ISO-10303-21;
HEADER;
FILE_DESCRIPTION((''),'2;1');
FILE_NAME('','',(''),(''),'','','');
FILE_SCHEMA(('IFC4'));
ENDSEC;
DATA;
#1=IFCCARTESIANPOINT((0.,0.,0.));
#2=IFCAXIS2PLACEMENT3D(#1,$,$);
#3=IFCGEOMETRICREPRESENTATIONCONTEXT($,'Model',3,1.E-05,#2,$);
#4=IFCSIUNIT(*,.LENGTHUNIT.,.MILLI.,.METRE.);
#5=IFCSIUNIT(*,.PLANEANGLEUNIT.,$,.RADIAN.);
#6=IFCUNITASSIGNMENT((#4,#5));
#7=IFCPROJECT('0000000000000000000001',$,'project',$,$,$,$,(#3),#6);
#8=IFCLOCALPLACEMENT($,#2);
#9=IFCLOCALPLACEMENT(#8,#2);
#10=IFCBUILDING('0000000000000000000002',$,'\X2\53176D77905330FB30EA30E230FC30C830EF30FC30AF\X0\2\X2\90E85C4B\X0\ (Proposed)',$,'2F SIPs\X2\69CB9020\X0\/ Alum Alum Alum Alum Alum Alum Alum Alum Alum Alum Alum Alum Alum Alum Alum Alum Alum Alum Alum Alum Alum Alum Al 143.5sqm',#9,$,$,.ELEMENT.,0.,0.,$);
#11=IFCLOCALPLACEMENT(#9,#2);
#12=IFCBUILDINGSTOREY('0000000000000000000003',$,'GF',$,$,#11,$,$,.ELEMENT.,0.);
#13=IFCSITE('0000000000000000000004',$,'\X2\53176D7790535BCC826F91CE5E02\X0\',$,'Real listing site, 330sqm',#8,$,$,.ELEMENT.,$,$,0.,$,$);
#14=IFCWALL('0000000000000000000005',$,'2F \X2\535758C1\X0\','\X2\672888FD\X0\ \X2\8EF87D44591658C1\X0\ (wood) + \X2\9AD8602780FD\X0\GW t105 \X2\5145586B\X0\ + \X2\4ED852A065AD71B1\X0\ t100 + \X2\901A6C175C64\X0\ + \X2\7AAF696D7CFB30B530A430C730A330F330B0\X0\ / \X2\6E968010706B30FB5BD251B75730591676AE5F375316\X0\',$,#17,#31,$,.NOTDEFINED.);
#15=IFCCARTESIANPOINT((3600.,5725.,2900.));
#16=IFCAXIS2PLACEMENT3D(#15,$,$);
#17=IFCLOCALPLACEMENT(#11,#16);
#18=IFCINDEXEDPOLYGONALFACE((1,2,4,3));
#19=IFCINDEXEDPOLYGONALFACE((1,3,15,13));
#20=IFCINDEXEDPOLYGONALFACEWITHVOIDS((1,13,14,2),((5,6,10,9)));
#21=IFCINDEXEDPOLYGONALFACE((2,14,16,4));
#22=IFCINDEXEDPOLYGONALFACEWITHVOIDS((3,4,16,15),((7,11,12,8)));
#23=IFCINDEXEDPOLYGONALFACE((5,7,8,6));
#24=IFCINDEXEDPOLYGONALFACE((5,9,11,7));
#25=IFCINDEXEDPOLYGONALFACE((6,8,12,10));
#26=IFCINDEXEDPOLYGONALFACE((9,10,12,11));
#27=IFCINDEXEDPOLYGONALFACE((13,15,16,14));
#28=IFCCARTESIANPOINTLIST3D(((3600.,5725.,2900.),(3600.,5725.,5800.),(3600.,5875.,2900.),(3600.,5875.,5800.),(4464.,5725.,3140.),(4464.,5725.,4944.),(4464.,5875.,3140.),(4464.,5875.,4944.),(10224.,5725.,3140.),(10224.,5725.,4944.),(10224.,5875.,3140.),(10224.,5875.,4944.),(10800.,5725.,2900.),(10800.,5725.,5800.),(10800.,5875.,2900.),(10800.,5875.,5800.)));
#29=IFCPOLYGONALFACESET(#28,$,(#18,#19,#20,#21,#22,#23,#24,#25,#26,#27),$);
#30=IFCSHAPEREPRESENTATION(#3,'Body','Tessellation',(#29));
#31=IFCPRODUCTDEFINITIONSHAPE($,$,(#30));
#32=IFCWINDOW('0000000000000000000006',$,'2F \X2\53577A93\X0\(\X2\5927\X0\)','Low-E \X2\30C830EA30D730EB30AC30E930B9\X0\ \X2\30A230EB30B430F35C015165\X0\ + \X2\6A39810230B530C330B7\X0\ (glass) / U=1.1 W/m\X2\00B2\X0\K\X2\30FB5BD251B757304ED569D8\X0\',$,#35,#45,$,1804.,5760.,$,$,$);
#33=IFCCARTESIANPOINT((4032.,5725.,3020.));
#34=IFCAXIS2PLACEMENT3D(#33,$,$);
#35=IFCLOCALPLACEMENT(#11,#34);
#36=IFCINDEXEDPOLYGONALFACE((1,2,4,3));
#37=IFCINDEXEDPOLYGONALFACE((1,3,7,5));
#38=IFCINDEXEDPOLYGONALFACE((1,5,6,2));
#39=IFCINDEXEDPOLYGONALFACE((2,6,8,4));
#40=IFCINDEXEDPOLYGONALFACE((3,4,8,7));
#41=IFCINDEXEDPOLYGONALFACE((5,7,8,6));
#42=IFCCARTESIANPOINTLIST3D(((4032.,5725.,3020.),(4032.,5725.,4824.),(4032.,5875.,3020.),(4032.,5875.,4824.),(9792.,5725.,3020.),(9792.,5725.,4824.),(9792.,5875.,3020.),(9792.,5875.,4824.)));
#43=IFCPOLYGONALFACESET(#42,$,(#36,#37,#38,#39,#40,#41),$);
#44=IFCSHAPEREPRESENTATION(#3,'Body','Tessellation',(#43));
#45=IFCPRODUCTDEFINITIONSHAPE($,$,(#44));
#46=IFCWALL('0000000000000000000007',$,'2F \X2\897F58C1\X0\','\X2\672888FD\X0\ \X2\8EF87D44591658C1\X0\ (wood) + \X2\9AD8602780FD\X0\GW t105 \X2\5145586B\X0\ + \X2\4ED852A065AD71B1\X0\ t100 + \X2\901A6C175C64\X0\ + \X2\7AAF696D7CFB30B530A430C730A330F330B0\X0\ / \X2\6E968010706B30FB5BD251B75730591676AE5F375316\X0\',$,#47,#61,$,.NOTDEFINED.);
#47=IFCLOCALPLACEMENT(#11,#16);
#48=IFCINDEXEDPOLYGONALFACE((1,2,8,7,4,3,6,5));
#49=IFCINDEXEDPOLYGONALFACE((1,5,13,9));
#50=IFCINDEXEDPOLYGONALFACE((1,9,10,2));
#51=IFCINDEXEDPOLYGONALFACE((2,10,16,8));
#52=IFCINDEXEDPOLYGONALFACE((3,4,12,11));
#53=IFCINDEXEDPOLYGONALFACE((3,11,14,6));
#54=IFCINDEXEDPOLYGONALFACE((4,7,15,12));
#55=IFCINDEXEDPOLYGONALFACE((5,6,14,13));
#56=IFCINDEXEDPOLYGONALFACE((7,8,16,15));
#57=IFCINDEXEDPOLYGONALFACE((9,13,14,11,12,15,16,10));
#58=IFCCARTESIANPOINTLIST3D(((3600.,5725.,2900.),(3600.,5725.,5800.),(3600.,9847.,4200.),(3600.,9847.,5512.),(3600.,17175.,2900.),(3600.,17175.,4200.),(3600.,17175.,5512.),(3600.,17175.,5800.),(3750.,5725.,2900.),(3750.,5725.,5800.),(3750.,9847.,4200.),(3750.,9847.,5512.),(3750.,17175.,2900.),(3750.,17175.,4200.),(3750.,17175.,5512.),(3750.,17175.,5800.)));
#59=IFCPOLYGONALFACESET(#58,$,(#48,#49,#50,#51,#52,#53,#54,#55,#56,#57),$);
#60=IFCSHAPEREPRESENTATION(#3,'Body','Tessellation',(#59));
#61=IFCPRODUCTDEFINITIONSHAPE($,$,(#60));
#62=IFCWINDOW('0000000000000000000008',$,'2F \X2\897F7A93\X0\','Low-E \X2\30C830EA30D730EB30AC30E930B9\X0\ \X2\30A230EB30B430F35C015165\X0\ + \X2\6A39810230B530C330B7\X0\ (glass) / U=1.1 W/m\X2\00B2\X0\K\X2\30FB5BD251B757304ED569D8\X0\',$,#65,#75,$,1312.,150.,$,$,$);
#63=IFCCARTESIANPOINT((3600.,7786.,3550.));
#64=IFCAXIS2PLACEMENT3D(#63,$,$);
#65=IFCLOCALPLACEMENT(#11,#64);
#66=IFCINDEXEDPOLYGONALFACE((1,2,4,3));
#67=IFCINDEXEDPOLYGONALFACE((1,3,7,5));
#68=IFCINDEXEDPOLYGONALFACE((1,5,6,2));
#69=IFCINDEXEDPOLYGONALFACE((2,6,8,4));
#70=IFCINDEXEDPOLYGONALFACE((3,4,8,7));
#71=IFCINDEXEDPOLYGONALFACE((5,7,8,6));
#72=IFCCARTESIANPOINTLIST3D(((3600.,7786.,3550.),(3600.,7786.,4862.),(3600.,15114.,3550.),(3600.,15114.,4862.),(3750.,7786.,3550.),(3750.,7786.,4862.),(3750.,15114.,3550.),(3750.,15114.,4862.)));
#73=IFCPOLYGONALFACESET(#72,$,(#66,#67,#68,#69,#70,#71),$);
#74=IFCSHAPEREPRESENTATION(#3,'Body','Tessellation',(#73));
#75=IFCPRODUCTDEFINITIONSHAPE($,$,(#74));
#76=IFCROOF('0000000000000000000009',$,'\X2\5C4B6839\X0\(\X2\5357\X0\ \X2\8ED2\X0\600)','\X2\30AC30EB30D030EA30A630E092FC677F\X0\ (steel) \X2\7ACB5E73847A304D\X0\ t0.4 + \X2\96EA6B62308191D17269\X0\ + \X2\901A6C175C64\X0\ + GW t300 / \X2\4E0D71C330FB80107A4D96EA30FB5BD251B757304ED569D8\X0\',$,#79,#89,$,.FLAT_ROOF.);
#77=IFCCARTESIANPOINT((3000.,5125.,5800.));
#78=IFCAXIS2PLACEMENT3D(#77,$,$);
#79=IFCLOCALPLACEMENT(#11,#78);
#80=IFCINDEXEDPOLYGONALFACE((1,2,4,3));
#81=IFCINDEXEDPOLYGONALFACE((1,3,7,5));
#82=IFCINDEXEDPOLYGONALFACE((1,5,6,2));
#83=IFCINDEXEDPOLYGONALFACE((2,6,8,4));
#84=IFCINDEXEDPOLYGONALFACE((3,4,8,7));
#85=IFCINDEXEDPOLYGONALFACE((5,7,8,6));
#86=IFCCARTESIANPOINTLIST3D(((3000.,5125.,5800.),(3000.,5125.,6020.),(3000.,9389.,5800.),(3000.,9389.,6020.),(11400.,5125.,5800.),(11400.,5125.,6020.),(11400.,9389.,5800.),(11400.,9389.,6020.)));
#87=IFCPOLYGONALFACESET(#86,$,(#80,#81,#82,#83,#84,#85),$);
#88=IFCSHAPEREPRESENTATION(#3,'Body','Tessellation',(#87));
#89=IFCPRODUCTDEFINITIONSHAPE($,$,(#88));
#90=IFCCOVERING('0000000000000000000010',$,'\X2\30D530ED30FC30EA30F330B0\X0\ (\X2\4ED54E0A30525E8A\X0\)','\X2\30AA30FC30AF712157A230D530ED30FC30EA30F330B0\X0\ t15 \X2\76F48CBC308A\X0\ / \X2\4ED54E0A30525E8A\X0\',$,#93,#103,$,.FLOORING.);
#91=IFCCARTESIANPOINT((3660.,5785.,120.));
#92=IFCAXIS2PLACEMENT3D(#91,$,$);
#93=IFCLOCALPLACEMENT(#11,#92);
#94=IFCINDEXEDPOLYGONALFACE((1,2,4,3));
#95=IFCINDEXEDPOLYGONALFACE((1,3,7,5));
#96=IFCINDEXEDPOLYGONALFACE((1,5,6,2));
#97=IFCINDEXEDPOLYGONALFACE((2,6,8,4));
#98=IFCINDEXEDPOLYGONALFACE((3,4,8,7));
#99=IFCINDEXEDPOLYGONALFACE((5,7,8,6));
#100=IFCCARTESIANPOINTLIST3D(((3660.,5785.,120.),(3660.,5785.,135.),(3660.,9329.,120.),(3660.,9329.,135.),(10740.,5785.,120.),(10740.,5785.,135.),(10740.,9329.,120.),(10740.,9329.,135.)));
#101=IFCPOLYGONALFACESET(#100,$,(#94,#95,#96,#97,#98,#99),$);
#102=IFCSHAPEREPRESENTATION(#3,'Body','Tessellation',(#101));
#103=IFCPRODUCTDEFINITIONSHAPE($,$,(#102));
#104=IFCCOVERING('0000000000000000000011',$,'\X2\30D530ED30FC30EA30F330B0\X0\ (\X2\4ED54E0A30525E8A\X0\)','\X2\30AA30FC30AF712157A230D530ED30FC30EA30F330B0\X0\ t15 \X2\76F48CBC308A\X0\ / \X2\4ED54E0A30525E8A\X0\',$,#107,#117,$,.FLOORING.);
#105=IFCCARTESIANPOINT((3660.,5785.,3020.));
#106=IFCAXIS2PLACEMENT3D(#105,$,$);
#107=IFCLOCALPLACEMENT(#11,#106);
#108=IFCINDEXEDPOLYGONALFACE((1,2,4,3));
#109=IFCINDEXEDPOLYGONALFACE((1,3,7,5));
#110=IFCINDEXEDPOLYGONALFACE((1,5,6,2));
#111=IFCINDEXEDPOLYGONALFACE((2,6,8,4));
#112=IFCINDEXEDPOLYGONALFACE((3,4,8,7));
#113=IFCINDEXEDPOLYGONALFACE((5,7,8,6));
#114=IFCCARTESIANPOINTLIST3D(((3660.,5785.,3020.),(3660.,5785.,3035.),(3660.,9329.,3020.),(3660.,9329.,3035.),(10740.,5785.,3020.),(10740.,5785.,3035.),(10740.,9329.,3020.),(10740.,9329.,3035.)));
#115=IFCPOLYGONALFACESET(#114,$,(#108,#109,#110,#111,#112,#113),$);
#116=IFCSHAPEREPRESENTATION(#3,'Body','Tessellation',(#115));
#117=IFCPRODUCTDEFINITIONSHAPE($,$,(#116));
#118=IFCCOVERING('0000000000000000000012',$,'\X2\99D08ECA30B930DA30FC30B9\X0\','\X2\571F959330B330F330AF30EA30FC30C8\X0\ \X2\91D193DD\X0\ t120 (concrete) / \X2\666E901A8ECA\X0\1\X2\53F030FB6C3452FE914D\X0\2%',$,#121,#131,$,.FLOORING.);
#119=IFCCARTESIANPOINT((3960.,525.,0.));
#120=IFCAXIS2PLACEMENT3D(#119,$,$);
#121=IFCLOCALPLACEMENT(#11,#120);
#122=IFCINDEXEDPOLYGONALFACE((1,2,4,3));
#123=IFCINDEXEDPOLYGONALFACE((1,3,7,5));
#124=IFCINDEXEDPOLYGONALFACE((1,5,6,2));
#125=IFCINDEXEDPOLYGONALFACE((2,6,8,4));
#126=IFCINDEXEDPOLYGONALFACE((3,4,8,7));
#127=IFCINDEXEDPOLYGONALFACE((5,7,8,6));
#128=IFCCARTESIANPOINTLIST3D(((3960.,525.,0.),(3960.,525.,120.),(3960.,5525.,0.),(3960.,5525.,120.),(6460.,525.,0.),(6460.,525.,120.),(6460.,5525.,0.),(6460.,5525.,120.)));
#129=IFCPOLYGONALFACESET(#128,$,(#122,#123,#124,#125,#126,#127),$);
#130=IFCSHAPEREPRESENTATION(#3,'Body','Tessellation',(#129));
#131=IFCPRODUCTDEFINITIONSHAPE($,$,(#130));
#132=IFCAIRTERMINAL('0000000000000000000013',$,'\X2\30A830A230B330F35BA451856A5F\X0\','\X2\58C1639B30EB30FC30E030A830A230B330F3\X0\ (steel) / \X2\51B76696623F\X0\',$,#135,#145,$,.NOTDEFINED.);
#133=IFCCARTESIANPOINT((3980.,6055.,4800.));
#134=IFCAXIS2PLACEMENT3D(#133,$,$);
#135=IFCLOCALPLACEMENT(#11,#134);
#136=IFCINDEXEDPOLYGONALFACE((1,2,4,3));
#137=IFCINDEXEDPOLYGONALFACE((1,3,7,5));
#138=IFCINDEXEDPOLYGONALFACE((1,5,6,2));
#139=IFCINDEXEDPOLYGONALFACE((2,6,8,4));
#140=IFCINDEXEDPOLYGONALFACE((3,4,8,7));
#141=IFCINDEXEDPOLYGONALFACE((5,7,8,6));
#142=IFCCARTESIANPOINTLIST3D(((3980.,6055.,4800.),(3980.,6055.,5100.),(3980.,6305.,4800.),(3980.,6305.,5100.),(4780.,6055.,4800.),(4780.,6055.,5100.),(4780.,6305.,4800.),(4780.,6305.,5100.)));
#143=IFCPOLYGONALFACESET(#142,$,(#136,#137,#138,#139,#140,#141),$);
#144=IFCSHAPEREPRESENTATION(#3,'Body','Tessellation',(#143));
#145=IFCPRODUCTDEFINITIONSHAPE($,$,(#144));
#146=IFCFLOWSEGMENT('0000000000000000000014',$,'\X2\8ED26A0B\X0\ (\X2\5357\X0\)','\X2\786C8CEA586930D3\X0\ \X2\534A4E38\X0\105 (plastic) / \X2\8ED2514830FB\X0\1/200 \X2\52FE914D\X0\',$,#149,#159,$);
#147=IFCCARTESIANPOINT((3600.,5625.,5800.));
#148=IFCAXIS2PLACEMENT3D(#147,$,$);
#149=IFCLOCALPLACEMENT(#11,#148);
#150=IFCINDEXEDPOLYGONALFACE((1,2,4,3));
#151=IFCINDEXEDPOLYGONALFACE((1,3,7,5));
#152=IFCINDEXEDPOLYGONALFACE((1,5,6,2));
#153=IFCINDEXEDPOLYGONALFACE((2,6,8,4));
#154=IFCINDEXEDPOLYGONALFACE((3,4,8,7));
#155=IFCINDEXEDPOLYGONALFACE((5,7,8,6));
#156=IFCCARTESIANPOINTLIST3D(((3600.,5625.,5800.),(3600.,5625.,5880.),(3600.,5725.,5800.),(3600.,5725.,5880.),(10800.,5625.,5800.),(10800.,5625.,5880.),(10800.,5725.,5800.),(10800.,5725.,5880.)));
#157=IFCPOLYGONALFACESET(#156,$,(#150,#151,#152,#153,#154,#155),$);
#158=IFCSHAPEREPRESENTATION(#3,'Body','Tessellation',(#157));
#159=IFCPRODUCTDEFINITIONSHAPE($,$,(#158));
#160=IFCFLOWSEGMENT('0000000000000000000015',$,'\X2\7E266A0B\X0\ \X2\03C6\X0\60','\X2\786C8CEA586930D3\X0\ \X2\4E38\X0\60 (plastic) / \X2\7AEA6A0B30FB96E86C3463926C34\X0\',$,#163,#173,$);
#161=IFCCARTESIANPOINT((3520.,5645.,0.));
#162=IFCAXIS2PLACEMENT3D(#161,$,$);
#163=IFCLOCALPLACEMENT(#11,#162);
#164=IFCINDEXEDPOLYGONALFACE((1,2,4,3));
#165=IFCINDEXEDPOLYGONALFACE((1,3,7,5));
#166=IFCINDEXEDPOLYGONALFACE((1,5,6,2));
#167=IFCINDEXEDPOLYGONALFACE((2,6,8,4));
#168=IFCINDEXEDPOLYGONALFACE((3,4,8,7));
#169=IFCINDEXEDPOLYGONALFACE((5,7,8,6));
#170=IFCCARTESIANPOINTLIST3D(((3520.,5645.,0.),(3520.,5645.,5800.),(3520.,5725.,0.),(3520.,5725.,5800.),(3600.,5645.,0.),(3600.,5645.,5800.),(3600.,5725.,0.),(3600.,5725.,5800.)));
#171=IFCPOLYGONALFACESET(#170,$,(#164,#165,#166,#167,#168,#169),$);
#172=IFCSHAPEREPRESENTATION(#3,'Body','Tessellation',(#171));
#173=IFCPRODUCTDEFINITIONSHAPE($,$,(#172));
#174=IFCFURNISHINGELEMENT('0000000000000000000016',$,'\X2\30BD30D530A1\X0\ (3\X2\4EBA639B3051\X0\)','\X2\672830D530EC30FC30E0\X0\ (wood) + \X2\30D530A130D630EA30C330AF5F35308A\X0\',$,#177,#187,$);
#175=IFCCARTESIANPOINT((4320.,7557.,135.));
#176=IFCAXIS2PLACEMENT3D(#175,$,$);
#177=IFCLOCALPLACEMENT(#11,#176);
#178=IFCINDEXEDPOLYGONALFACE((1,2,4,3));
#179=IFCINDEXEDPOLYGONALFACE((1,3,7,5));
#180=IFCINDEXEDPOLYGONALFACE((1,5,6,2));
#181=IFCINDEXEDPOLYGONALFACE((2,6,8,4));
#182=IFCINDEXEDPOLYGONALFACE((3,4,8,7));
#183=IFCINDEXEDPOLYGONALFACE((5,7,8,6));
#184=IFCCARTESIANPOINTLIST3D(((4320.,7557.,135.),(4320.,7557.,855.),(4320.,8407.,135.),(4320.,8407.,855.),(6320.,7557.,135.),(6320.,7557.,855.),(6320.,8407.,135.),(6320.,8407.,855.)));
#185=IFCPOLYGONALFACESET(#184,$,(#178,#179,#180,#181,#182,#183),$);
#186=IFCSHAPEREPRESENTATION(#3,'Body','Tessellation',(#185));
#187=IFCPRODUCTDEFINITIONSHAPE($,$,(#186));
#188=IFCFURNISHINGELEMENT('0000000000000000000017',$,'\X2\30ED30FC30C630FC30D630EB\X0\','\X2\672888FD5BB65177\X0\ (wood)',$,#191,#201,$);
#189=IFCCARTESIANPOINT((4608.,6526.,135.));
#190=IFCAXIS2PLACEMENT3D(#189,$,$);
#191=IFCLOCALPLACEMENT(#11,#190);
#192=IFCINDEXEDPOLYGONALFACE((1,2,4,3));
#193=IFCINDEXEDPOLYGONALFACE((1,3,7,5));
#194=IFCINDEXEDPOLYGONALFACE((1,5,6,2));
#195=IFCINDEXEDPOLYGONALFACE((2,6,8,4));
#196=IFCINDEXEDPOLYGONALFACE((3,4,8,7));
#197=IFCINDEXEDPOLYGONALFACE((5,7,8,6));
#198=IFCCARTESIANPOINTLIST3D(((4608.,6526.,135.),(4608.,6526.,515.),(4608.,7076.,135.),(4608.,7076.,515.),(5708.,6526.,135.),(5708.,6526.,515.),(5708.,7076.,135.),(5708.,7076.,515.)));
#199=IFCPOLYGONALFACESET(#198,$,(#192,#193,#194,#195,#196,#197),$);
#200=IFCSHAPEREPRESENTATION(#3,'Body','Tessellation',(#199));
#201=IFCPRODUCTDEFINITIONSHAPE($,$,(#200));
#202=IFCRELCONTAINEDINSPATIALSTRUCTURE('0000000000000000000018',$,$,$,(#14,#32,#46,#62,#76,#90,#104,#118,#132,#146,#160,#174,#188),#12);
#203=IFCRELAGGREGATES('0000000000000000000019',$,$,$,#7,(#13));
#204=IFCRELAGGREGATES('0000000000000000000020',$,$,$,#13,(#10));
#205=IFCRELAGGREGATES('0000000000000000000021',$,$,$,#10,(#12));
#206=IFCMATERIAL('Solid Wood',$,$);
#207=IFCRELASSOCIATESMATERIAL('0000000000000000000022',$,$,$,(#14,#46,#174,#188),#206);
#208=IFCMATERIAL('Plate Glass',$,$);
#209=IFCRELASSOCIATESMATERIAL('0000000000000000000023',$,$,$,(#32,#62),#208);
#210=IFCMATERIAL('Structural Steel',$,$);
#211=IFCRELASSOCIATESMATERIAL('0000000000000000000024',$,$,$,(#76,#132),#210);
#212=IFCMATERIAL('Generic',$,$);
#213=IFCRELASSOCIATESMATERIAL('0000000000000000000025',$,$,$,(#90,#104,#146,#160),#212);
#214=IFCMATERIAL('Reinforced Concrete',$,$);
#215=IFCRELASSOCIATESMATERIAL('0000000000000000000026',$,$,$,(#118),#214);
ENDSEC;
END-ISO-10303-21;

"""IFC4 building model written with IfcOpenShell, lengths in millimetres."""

from ifc_helpers import new_model, si_unit, frame, frame_2d, origin, place, context, project, spatial, rectangle, extrude, material, element, fill, save


model = new_model("IFC4")

# Units and contexts
model_context = context("Model", 3, precision=1e-05, world=origin())
ifc_project = project(units=[si_unit("LENGTHUNIT", "METRE", prefix="MILLI"), si_unit("PLANEANGLEUNIT", "RADIAN")], contexts=[model_context])

# Site, building, storey
site_placement = place(None, origin())
site = spatial("IfcSite", under=ifc_project, at=site_placement, Name="北海道富良野市", ObjectType="Real listing site, 330sqm", CompositionType="ELEMENT", RefElevation=0.0)
building_placement = place(site_placement, origin())
building = spatial("IfcBuilding", under=site, at=building_placement, Name="北海道・リモートワーク2部屋 (Proposed)", ObjectType="2F SIPs構造/ Alum Alum Alum Alum Alum Alum Alum Alum Alum Alum Alum Alum Alum Alum Alum Alum Alum Alum Alum Alum Alum Alum Al 143.5sqm", CompositionType="ELEMENT", ElevationOfRefHeight=0.0, ElevationOfTerrain=0.0)
storey_placement = place(building_placement, origin())
storey = spatial("IfcBuildingStorey", under=building, at=storey_placement, Name="GF", CompositionType="ELEMENT", Elevation=0.0)

# Shared definitions
ifc_material_1 = material(Name="Solid Wood")

# Shared definitions
ifc_material_2 = material(Name="Reinforced Concrete")

# Shared definitions
ifc_material_3 = material(Name="Plate Glass")

# Walls, openings, windows
wall_1_placement = place(storey_placement, frame((3600.0, 5725.0, 2900.0)))
wall_1 = element("IfcWall", 1, at=wall_1_placement, inside=storey, material=ifc_material_1, Name="2F 南壁", Description="木製 軸組外壁 (wood) + 高性能GW t105 充填 + 付加断熱 t100 + 通気層 + 窯業系サイディング / 準耐火・寒冷地外皮強化", PredefinedType="NOTDEFINED", context=model_context, shape_type="SweptSolid", body=[
    extrude(rectangle(XDim=7200.0, YDim=150.0, at=frame_2d((3600.0, 75.0))), frame((3600.0, 5725.0, 2900.0)), (0.0, 0.0, 1.0), 2900.0),
])
opening_1_placement = place(storey_placement, frame((4032.0, 5725.0, 3020.0)))
opening_1 = element("IfcOpeningElement", 2, at=opening_1_placement, cuts=wall_1, PredefinedType="NOTDEFINED", context=model_context, shape_type="SweptSolid", body=[
    extrude(rectangle(XDim=5760.0, YDim=150.0, at=frame_2d((2880.0, 75.0))), frame((4032.0, 5725.0, 3020.0)), (0.0, 0.0, 1.0), 1804.0),
])
window_1_placement = place(storey_placement, frame((4032.0, 5725.0, 3020.0)))
window_1 = element("IfcWindow", 3, at=window_1_placement, inside=storey, material=ifc_material_3, Name="2F 南窓(大)", Description="Low-E トリプルガラス アルゴン封入 + 樹脂サッシ (glass) / U=1.1 W/m²K・寒冷地仕様", OverallHeight=1804.0, OverallWidth=5760.0, context=model_context, shape_type="SweptSolid", body=[
    extrude(rectangle(XDim=5760.0, YDim=150.0, at=frame_2d((2880.0, 75.0))), frame((4032.0, 5725.0, 3020.0)), (0.0, 0.0, 1.0), 1804.0),
])
fill(opening_1, window_1)
wall_2_placement = place(storey_placement, frame((3600.0, 5725.0, 2900.0)))
wall_2 = element("IfcWall", 4, at=wall_2_placement, inside=storey, material=ifc_material_1, Name="2F 西壁", Description="木製 軸組外壁 (wood) + 高性能GW t105 充填 + 付加断熱 t100 + 通気層 + 窯業系サイディング / 準耐火・寒冷地外皮強化", PredefinedType="NOTDEFINED", context=model_context, shape_type="SweptSolid", body=[
    extrude(rectangle(XDim=150.0, YDim=11450.0, at=frame_2d((75.0, 5725.0))), frame((3600.0, 5725.0, 2900.0)), (0.0, 0.0, 1.0), 2900.0),
])
opening_2_placement = place(storey_placement, frame((3600.0, 7786.0, 3550.0)))
opening_2 = element("IfcOpeningElement", 5, at=opening_2_placement, cuts=wall_2, PredefinedType="NOTDEFINED", context=model_context, shape_type="SweptSolid", body=[
    extrude(rectangle(XDim=150.0, YDim=7328.0, at=frame_2d((75.0, 3664.0))), frame((3600.0, 7786.0, 3550.0)), (0.0, 0.0, 1.0), 1312.0),
])
window_2_placement = place(storey_placement, frame((3600.0, 7786.0, 3550.0)))
window_2 = element("IfcWindow", 6, at=window_2_placement, inside=storey, material=ifc_material_3, Name="2F 西窓", Description="Low-E トリプルガラス アルゴン封入 + 樹脂サッシ (glass) / U=1.1 W/m²K・寒冷地仕様", OverallHeight=1312.0, OverallWidth=150.0, context=model_context, shape_type="SweptSolid", body=[
    extrude(rectangle(XDim=150.0, YDim=7328.0, at=frame_2d((75.0, 3664.0))), frame((3600.0, 7786.0, 3550.0)), (0.0, 0.0, 1.0), 1312.0),
])
fill(opening_2, window_2)

# Roof
ifc_material_4 = material(Name="Structural Steel")
for number, where, name in (
    (7, (3000.0, 5125.0, 5800.0), "屋根(南 軒600)"),
):
    element("IfcRoof", number, at=place(storey_placement, frame(where)), inside=storey, material=ifc_material_4, Name=name, Description="ガルバリウム鋼板 (steel) 立平葺き t0.4 + 雪止め金物 + 通気層 + GW t300 / 不燃・耐積雪・寒冷地仕様", PredefinedType="FLAT_ROOF", context=model_context, shape_type="SweptSolid", body=[
        extrude(rectangle(XDim=8400.0, YDim=4264.0, at=frame_2d((4200.0, 2132.0))), frame((3000.0, 5125.0, 5800.0)), (0.0, 0.0, 1.0), 220.0),
    ])

# Coverings
ifc_material_5 = material(Name="Generic")
covering_1_placement = place(storey_placement, frame((3660.0, 5785.0, 120.0)))
element("IfcCovering", 8, at=covering_1_placement, inside=storey, material=ifc_material_5, Name="フローリング (仕上げ床)", Description="オーク無垢フローリング t15 直貼り / 仕上げ床", PredefinedType="FLOORING", context=model_context, shape_type="SweptSolid", body=[
    extrude(rectangle(XDim=7080.0, YDim=3544.0, at=frame_2d((3540.0, 1772.0))), frame((3660.0, 5785.0, 120.0)), (0.0, 0.0, 1.0), 15.0),
])
covering_2_placement = place(storey_placement, frame((3660.0, 5785.0, 3020.0)))
element("IfcCovering", 9, at=covering_2_placement, inside=storey, material=ifc_material_5, Name="フローリング (仕上げ床)", Description="オーク無垢フローリング t15 直貼り / 仕上げ床", PredefinedType="FLOORING", context=model_context, shape_type="SweptSolid", body=[
    extrude(rectangle(XDim=7080.0, YDim=3544.0, at=frame_2d((3540.0, 1772.0))), frame((3660.0, 5785.0, 3020.0)), (0.0, 0.0, 1.0), 15.0),
])
covering_3_placement = place(storey_placement, frame((3960.0, 525.0, 0.0)))
element("IfcCovering", 10, at=covering_3_placement, inside=storey, material=ifc_material_2, Name="駐車スペース", Description="土間コンクリート 金鏝 t120 (concrete) / 普通車1台・水勾配2%", PredefinedType="FLOORING", context=model_context, shape_type="SweptSolid", body=[
    extrude(rectangle(XDim=2500.0, YDim=5000.0, at=frame_2d((1250.0, 2500.0))), frame((3960.0, 525.0, 0.0)), (0.0, 0.0, 1.0), 120.0),
])

# Air terminal
air_terminal_placement = place(storey_placement, frame((3980.0, 6055.0, 4800.0)))
element("IfcAirTerminal", 11, at=air_terminal_placement, inside=storey, material=ifc_material_4, Name="エアコン室内機", Description="壁掛ルームエアコン (steel) / 冷暖房", PredefinedType="NOTDEFINED", context=model_context, shape_type="SweptSolid", body=[
    extrude(rectangle(XDim=800.0, YDim=250.0, at=frame_2d((400.0, 125.0))), frame((3980.0, 6055.0, 4800.0)), (0.0, 0.0, 1.0), 300.0),
])

# Flow segments
flow_segment_1_placement = place(storey_placement, frame((3600.0, 5625.0, 5800.0)))
element("IfcFlowSegment", 12, at=flow_segment_1_placement, inside=storey, material=ifc_material_5, Name="軒樋 (南)", Description="硬質塩ビ 半丸105 (plastic) / 軒先・1/200 勾配", context=model_context, shape_type="SweptSolid", body=[
    extrude(rectangle(XDim=7200.0, YDim=100.0, at=frame_2d((3600.0, 50.0))), frame((3600.0, 5625.0, 5800.0)), (0.0, 0.0, 1.0), 80.0),
])
flow_segment_2_placement = place(storey_placement, frame((3520.0, 5645.0, 0.0)))
element("IfcFlowSegment", 13, at=flow_segment_2_placement, inside=storey, material=ifc_material_5, Name="縦樋 φ60", Description="硬質塩ビ 丸60 (plastic) / 竪樋・雨水排水", context=model_context, shape_type="SweptSolid", body=[
    extrude(rectangle(XDim=80.0, YDim=80.0, at=frame_2d((40.0, 40.0))), frame((3520.0, 5645.0, 0.0)), (0.0, 0.0, 1.0), 5800.0),
])

# Furnishing elements
furnishing_1_placement = place(storey_placement, frame((4320.0, 7557.0, 135.0)))
element("IfcFurnishingElement", 14, at=furnishing_1_placement, inside=storey, material=ifc_material_1, Name="ソファ (3人掛け)", Description="木フレーム (wood) + ファブリック張り", context=model_context, shape_type="SweptSolid", body=[
    extrude(rectangle(XDim=2000.0, YDim=850.0, at=frame_2d((1000.0, 425.0))), frame((4320.0, 7557.0, 135.0)), (0.0, 0.0, 1.0), 720.0),
])
furnishing_2_placement = place(storey_placement, frame((4608.0, 6526.0, 135.0)))
element("IfcFurnishingElement", 15, at=furnishing_2_placement, inside=storey, material=ifc_material_1, Name="ローテーブル", Description="木製家具 (wood)", context=model_context, shape_type="SweptSolid", body=[
    extrude(rectangle(XDim=1100.0, YDim=550.0, at=frame_2d((550.0, 275.0))), frame((4608.0, 6526.0, 135.0)), (0.0, 0.0, 1.0), 380.0),
])

save(model, "model.ifc")
